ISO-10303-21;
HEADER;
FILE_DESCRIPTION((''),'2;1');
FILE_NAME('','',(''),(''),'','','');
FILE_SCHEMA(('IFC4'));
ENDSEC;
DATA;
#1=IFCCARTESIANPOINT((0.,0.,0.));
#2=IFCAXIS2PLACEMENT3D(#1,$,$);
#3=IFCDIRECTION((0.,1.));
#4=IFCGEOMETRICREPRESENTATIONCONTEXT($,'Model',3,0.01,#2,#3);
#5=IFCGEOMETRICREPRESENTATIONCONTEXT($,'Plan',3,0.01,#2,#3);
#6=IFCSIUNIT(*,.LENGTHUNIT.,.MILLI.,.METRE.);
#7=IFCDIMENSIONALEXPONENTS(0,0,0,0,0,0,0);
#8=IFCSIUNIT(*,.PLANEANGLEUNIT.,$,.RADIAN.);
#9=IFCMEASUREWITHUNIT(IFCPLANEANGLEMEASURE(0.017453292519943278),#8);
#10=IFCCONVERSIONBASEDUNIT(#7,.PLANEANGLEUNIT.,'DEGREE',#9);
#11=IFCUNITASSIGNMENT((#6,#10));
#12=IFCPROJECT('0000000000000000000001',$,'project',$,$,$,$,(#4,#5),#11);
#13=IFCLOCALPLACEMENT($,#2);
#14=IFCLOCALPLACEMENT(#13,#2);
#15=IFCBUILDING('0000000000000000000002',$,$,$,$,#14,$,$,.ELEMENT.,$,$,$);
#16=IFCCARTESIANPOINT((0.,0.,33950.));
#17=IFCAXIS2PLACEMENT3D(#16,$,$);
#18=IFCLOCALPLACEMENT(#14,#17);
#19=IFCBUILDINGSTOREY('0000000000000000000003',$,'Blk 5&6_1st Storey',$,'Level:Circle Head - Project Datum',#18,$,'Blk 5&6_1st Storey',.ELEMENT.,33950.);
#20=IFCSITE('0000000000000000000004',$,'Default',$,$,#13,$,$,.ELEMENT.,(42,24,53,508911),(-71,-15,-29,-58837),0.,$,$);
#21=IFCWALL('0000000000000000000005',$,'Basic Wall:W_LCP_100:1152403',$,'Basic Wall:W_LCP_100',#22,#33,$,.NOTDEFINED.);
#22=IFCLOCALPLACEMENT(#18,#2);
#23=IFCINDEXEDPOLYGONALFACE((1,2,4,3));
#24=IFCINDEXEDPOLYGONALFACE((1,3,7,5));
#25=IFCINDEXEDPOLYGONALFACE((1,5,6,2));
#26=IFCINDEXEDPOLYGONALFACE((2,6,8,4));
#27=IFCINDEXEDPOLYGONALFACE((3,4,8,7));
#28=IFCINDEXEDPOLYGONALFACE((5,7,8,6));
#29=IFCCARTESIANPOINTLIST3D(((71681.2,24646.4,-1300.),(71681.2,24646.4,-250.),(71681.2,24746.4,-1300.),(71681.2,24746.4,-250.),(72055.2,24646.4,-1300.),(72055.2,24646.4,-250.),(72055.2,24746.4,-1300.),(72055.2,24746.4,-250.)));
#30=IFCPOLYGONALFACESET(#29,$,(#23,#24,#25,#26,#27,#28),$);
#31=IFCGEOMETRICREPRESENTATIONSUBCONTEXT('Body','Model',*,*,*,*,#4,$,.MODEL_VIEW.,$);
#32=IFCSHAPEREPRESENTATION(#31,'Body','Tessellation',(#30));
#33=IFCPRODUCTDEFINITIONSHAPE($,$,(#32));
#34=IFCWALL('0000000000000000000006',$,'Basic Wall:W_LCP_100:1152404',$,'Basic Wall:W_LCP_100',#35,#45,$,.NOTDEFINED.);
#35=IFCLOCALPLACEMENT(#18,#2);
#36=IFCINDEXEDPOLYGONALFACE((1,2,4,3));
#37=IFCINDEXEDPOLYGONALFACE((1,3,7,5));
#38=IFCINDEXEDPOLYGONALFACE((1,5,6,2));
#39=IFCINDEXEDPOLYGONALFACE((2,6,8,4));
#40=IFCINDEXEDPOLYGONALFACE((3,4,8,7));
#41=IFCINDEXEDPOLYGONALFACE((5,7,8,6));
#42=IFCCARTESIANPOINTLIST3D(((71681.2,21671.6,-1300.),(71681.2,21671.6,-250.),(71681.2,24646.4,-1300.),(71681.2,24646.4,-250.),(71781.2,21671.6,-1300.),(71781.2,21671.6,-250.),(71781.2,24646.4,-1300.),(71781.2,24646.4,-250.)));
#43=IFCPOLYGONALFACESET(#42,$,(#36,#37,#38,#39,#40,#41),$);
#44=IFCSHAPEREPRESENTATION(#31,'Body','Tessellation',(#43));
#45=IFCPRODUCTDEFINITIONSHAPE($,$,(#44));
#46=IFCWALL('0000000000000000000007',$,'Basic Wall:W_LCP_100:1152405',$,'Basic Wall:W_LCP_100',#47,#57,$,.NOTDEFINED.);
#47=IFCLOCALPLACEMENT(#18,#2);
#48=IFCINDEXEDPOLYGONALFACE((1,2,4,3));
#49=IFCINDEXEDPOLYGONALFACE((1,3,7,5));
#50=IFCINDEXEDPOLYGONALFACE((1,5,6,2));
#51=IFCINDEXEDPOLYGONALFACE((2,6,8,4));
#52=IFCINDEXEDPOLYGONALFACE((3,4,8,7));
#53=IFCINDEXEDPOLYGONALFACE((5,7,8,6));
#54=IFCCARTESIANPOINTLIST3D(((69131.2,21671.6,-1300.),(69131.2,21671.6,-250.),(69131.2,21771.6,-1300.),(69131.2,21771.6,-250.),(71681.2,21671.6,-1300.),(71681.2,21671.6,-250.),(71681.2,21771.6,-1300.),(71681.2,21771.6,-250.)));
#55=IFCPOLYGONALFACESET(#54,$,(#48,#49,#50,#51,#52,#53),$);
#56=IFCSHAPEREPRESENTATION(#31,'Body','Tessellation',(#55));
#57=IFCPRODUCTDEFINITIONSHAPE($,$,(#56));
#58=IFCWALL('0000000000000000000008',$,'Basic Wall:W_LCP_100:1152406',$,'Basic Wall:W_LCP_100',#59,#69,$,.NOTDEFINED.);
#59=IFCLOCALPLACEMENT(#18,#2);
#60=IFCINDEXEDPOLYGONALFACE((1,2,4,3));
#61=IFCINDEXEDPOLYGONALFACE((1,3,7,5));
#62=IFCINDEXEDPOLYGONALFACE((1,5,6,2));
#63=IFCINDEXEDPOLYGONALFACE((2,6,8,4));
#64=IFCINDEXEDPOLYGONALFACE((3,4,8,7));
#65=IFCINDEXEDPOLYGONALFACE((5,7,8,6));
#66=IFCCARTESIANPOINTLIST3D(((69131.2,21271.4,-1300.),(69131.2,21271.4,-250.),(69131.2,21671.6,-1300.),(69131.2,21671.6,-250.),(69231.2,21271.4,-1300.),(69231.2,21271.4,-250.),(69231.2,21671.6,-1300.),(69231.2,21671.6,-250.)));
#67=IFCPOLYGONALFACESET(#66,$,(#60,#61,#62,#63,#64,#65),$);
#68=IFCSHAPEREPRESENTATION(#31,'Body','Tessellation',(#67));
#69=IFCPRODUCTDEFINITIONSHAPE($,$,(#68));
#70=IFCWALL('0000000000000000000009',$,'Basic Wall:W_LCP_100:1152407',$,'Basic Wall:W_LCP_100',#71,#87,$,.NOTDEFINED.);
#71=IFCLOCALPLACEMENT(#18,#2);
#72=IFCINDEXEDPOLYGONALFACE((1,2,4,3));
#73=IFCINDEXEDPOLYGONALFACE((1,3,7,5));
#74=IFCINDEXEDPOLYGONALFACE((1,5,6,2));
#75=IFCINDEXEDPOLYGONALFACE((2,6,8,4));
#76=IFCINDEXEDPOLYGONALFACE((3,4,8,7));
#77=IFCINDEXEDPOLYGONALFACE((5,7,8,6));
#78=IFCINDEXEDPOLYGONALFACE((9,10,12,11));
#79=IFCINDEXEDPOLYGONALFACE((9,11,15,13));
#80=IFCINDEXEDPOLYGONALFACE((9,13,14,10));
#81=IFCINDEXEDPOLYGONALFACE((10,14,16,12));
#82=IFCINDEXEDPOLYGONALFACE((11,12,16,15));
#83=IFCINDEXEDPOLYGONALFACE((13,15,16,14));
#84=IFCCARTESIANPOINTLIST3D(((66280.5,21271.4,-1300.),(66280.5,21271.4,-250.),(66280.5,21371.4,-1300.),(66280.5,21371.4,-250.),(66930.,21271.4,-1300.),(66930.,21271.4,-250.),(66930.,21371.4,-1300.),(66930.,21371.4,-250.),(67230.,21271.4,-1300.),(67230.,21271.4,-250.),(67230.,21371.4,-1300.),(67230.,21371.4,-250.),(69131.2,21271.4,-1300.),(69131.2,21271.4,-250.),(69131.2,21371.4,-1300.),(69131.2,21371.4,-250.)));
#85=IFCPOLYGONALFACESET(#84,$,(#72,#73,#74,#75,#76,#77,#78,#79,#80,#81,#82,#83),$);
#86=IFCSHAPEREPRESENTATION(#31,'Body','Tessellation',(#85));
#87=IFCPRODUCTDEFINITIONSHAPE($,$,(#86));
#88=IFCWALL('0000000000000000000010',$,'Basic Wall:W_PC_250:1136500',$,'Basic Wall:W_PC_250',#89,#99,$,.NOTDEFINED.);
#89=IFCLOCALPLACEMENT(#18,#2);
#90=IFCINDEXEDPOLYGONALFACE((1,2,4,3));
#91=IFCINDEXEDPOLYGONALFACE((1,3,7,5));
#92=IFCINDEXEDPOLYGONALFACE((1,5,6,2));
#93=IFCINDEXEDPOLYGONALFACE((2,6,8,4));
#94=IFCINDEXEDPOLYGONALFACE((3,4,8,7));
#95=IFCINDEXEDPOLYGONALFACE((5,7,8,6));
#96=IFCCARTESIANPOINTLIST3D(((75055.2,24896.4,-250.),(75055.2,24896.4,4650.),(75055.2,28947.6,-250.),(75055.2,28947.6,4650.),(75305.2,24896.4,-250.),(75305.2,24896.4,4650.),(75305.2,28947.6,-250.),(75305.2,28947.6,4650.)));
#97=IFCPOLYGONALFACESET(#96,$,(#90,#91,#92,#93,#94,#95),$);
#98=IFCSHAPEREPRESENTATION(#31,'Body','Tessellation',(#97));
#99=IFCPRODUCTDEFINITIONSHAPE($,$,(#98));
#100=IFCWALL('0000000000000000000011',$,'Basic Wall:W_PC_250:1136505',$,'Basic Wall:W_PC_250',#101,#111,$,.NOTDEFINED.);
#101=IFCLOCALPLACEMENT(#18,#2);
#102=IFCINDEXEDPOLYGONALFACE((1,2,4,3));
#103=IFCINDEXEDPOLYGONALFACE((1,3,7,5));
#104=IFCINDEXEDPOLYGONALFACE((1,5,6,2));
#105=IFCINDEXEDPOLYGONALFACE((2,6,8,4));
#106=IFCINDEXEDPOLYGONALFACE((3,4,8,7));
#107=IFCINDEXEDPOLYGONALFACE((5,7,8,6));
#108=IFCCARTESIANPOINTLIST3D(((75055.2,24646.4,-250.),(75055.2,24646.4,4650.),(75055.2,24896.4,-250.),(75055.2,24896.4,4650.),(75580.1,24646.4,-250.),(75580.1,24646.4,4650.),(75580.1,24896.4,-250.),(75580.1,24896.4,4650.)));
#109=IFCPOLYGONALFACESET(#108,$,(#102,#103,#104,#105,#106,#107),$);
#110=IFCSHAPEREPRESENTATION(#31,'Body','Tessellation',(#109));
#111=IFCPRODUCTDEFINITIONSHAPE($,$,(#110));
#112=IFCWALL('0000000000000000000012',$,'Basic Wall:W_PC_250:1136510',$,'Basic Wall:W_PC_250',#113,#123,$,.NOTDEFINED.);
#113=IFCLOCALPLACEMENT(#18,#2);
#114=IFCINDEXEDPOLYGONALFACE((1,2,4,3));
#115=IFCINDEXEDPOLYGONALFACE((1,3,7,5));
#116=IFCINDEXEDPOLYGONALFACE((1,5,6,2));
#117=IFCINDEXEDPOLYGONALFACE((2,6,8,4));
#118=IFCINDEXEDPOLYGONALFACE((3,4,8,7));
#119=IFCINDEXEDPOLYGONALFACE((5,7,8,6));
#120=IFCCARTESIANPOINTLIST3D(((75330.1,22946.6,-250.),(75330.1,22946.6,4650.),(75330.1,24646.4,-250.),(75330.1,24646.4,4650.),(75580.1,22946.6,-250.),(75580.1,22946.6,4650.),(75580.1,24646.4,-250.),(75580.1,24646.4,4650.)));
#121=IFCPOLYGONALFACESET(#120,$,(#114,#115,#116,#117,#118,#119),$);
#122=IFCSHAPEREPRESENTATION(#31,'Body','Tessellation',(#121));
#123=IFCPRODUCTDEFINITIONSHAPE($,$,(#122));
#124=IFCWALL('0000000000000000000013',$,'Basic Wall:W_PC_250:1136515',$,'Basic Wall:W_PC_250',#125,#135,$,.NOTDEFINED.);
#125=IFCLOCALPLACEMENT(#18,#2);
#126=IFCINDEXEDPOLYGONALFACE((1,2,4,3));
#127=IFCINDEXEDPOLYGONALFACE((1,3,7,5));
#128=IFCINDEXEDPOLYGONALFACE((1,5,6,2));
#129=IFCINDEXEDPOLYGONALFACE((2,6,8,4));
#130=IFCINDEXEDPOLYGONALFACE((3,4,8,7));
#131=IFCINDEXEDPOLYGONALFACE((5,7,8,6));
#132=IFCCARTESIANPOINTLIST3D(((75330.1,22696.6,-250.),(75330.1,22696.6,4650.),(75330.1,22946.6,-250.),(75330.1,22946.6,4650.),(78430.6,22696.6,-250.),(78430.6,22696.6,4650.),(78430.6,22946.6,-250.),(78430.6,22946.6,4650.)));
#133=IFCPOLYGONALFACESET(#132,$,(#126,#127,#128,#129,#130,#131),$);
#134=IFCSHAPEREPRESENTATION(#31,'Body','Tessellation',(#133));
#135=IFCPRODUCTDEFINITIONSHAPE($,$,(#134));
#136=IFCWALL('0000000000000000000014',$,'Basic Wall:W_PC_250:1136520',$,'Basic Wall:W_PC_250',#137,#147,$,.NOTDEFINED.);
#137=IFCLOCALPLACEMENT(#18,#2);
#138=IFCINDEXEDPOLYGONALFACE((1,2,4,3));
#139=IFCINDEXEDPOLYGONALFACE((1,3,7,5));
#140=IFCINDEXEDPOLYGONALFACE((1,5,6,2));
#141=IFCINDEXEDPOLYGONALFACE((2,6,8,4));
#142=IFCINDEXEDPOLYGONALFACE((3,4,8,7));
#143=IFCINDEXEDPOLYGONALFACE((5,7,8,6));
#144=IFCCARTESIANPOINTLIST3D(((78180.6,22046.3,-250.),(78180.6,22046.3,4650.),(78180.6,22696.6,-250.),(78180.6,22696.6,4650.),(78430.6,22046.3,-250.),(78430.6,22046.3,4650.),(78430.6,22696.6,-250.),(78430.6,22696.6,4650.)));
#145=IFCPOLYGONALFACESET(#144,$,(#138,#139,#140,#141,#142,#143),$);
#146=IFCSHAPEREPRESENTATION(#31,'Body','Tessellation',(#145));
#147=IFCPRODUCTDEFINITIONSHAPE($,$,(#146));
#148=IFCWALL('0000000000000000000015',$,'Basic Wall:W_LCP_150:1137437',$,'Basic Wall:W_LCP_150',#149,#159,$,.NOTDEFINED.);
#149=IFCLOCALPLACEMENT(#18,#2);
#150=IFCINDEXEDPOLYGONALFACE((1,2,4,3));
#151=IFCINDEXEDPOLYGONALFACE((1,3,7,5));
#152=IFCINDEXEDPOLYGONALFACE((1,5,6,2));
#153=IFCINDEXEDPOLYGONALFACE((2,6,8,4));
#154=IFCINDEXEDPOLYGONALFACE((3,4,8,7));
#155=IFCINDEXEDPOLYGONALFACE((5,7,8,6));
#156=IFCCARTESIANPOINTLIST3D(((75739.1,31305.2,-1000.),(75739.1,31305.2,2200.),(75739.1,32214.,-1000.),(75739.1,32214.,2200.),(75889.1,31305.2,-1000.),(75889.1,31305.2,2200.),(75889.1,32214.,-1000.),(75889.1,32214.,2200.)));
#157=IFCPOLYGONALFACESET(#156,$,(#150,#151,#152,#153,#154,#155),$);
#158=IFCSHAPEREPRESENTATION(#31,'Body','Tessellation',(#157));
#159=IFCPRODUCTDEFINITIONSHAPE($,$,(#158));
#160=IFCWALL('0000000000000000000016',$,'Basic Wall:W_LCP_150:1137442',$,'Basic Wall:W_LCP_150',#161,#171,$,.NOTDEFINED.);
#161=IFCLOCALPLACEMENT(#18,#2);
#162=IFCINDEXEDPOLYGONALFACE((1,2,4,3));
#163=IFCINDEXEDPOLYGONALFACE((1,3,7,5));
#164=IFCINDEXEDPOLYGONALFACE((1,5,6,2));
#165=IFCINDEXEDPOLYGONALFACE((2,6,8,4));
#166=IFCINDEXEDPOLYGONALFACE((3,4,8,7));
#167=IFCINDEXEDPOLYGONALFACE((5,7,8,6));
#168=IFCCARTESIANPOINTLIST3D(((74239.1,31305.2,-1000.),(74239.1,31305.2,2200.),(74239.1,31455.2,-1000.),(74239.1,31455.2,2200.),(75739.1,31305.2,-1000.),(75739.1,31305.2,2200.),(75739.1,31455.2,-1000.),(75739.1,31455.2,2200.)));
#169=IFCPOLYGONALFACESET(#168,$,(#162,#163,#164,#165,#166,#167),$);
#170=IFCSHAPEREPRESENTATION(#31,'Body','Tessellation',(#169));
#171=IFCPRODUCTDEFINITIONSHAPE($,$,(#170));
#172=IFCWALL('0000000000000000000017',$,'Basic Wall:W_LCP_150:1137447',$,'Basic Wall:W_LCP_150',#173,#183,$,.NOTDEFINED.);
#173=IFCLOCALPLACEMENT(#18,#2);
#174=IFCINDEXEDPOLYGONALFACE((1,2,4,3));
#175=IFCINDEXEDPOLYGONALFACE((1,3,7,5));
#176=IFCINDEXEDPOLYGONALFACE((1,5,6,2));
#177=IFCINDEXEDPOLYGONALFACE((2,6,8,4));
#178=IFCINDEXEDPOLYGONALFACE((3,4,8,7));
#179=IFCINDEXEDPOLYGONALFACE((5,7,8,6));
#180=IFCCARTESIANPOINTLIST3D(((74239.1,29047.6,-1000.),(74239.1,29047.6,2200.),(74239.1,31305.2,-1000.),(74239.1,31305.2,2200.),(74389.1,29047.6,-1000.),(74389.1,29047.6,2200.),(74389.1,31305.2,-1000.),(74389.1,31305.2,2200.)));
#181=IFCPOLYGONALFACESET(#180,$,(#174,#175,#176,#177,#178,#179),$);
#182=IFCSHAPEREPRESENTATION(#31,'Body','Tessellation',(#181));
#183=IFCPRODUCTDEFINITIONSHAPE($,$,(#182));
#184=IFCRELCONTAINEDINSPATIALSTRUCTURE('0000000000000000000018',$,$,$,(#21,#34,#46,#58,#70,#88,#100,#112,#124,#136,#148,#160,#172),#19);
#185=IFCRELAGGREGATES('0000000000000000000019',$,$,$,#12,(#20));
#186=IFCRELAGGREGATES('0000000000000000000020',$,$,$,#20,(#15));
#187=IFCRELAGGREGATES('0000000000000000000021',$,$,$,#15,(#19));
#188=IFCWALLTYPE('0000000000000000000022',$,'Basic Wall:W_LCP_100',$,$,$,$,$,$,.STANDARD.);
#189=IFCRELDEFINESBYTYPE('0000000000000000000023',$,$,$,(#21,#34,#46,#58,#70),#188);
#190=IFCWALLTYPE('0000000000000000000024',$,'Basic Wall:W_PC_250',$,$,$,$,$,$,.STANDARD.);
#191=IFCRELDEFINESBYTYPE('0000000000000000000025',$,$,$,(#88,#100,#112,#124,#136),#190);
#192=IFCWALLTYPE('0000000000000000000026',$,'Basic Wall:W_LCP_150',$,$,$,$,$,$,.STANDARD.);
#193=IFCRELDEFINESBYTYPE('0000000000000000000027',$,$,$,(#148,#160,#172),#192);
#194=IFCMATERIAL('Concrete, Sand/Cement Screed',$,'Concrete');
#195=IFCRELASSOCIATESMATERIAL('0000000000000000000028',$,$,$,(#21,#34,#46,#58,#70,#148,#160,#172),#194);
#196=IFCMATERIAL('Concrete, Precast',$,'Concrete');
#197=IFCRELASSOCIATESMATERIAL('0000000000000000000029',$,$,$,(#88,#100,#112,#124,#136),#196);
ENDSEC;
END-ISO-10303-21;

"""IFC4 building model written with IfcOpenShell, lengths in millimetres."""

from ifc_helpers import new_model, entity, si_unit, converted_unit, direction, frame, origin, place, context, subcontext, project, spatial, indexed_curve, outline, extrude, material, type_object, element, save


model = new_model("IFC4")

# Units and contexts
model_context = context("Model", 3, precision=0.01, world=origin(), true_north=direction((0.0, 1.0)))
plan_context = context("Plan", 3, precision=0.01, world=origin(), true_north=direction((0.0, 1.0)))
body_context = subcontext(model_context, "Body", "Model", "MODEL_VIEW")
ifc_project = project(units=[si_unit("LENGTHUNIT", "METRE", prefix="MILLI"), converted_unit("PLANEANGLEUNIT", "DEGREE", entity("IfcPlaneAngleMeasure", 0.017453292519943278), si_unit("PLANEANGLEUNIT", "RADIAN"), dimensions=[0, 0, 0, 0, 0, 0, 0])], contexts=[model_context, plan_context])

# Site, building, storey
site_placement = place(None, origin())
site = spatial("IfcSite", under=ifc_project, at=site_placement, Name="Default", CompositionType="ELEMENT", RefLatitude=(42, 24, 53, 508911), RefLongitude=(-71, -15, -29, -58837), RefElevation=0.0)
building_placement = place(site_placement, origin())
building = spatial("IfcBuilding", under=site, at=building_placement, CompositionType="ELEMENT")
storey_placement = place(building_placement, frame((0.0, 0.0, 33950.0)))
storey = spatial("IfcBuildingStorey", under=building, at=storey_placement, Name="Blk 5&6_1st Storey", ObjectType="Level:Circle Head - Project Datum", LongName="Blk 5&6_1st Storey", CompositionType="ELEMENT", Elevation=33950.0)

# Walls
ifc_material_1 = material(Name="Concrete, Sand/Cement Screed", Category="Concrete")
wall_type_1 = type_object("IfcWallType", Name="Basic Wall:W_LCP_100", PredefinedType="STANDARD")
wall_1_placement = place(storey_placement, frame((72055.2, 24696.4, -1300.0), z_axis=(0.0, 0.0, 1.0), x_axis=(-1.0, 0.0, 0.0)))
element("IfcWall", 1, at=wall_1_placement, inside=storey, type_object=wall_type_1, material=ifc_material_1, Name="Basic Wall:W_LCP_100:1152403", ObjectType="Basic Wall:W_LCP_100", PredefinedType="NOTDEFINED", context=body_context, shape_type="SweptSolid", body=[
    extrude(outline(indexed_curve([(373.9, 50.0), (0.0, 50.0), (0.0, -50.0), (373.9, -50.0), (373.9, 50.0)], self_intersect=False)), origin(), (0.0, 0.0, 1.0), 1050.0),
])
wall_2_placement = place(storey_placement, frame((71731.2, 24646.4, -1300.0), z_axis=(0.0, 0.0, 1.0), x_axis=(0.0, -1.0, 0.0)))
element("IfcWall", 2, at=wall_2_placement, inside=storey, type_object=wall_type_1, material=ifc_material_1, Name="Basic Wall:W_LCP_100:1152404", ObjectType="Basic Wall:W_LCP_100", PredefinedType="NOTDEFINED", context=body_context, shape_type="SweptSolid", body=[
    extrude(outline(indexed_curve([(2974.8, 50.0), (0.0, 50.0), (0.0, -50.0), (2974.8, -50.0), (2974.8, 50.0)], self_intersect=False)), origin(), (0.0, 0.0, 1.0), 1050.0),
])
wall_3_placement = place(storey_placement, frame((71681.2, 21721.6, -1300.0), z_axis=(0.0, 0.0, 1.0), x_axis=(-1.0, 0.0, 0.0)))
element("IfcWall", 3, at=wall_3_placement, inside=storey, type_object=wall_type_1, material=ifc_material_1, Name="Basic Wall:W_LCP_100:1152405", ObjectType="Basic Wall:W_LCP_100", PredefinedType="NOTDEFINED", context=body_context, shape_type="SweptSolid", body=[
    extrude(outline(indexed_curve([(2550.0, 50.0), (0.0, 50.0), (0.0, -50.0), (2550.0, -50.0), (2550.0, 50.0)], self_intersect=False)), origin(), (0.0, 0.0, 1.0), 1050.0),
])
wall_4_placement = place(storey_placement, frame((69181.2, 21671.6, -1300.0), z_axis=(0.0, 0.0, 1.0), x_axis=(0.0, -1.0, 0.0)))
element("IfcWall", 4, at=wall_4_placement, inside=storey, type_object=wall_type_1, material=ifc_material_1, Name="Basic Wall:W_LCP_100:1152406", ObjectType="Basic Wall:W_LCP_100", PredefinedType="NOTDEFINED", context=body_context, shape_type="SweptSolid", body=[
    extrude(outline(indexed_curve([(400.2, 50.0), (0.0, 50.0), (0.0, -50.0), (400.2, -50.0), (400.2, 50.0)], self_intersect=False)), origin(), (0.0, 0.0, 1.0), 1050.0),
])

# Wall, opening
wall_5_placement = place(storey_placement, frame((69131.2, 21321.4, -1300.0), z_axis=(0.0, 0.0, 1.0), x_axis=(-1.0, 0.0, 0.0)))
wall_5 = element("IfcWall", 5, at=wall_5_placement, inside=storey, type_object=wall_type_1, material=ifc_material_1, Name="Basic Wall:W_LCP_100:1152407", ObjectType="Basic Wall:W_LCP_100", PredefinedType="NOTDEFINED", context=body_context, shape_type="SweptSolid", body=[
    extrude(outline(indexed_curve([(2850.7, 50.0), (0.0, 50.0), (0.0, -50.0), (2850.7, -50.0), (2850.7, 50.0)], self_intersect=False)), origin(), (0.0, 0.0, 1.0), 1050.0),
])
opening_placement = place(storey_placement, frame((69131.2, 21321.4, -1300.0), z_axis=(0.0, 0.0, 1.0), x_axis=(-1.0, 0.0, 0.0)))
element("IfcOpeningElement", 6, at=opening_placement, cuts=wall_5, PredefinedType="OPENING", context=body_context, shape_type="SweptSolid", body=[
    extrude(outline(indexed_curve([(-525.0, -50.0), (525.0, -50.0), (525.0, 50.0), (-525.0, 50.0), (-525.0, -50.0)], self_intersect=False)), frame((2201.2, 0.0, 525.0), z_axis=(-1.0, 0.0, 0.0), x_axis=(0.0, 0.0, 1.0)), (0.0, 0.0, 1.0), 300.0),
])

# Walls
ifc_material_2 = material(Name="Concrete, Precast", Category="Concrete")
wall_type_2 = type_object("IfcWallType", Name="Basic Wall:W_PC_250", PredefinedType="STANDARD")
wall_6_placement = place(storey_placement, frame((75180.2, 28947.6, -250.0), z_axis=(0.0, 0.0, 1.0), x_axis=(0.0, -1.0, 0.0)))
element("IfcWall", 7, at=wall_6_placement, inside=storey, type_object=wall_type_2, material=ifc_material_2, Name="Basic Wall:W_PC_250:1136500", ObjectType="Basic Wall:W_PC_250", PredefinedType="NOTDEFINED", context=body_context, shape_type="SweptSolid", body=[
    extrude(outline(indexed_curve([(4051.2, 125.0), (0.0, 125.0), (0.0, -125.0), (4051.2, -125.0), (4051.2, 125.0)], self_intersect=False)), origin(), (0.0, 0.0, 1.0), 4900.0),
])
wall_7_placement = place(storey_placement, frame((75055.2, 24771.4, -250.0)))
element("IfcWall", 8, at=wall_7_placement, inside=storey, type_object=wall_type_2, material=ifc_material_2, Name="Basic Wall:W_PC_250:1136505", ObjectType="Basic Wall:W_PC_250", PredefinedType="NOTDEFINED", context=body_context, shape_type="SweptSolid", body=[
    extrude(outline(indexed_curve([(524.9, 125.0), (0.0, 125.0), (0.0, -125.0), (524.9, -125.0), (524.9, 125.0)], self_intersect=False)), origin(), (0.0, 0.0, 1.0), 4900.0),
])
wall_8_placement = place(storey_placement, frame((75455.1, 24646.4, -250.0), z_axis=(0.0, 0.0, 1.0), x_axis=(0.0, -1.0, 0.0)))
element("IfcWall", 9, at=wall_8_placement, inside=storey, type_object=wall_type_2, material=ifc_material_2, Name="Basic Wall:W_PC_250:1136510", ObjectType="Basic Wall:W_PC_250", PredefinedType="NOTDEFINED", context=body_context, shape_type="SweptSolid", body=[
    extrude(outline(indexed_curve([(1699.8, 125.0), (0.0, 125.0), (0.0, -125.0), (1699.8, -125.0), (1699.8, 125.0)], self_intersect=False)), origin(), (0.0, 0.0, 1.0), 4900.0),
])
wall_9_placement = place(storey_placement, frame((75330.1, 22821.6, -250.0)))
element("IfcWall", 10, at=wall_9_placement, inside=storey, type_object=wall_type_2, material=ifc_material_2, Name="Basic Wall:W_PC_250:1136515", ObjectType="Basic Wall:W_PC_250", PredefinedType="NOTDEFINED", context=body_context, shape_type="SweptSolid", body=[
    extrude(outline(indexed_curve([(3100.5, 125.0), (0.0, 125.0), (0.0, -125.0), (3100.5, -125.0), (3100.5, 125.0)], self_intersect=False)), origin(), (0.0, 0.0, 1.0), 4900.0),
])
wall_10_placement = place(storey_placement, frame((78305.6, 22696.6, -250.0), z_axis=(0.0, 0.0, 1.0), x_axis=(0.0, -1.0, 0.0)))
element("IfcWall", 11, at=wall_10_placement, inside=storey, type_object=wall_type_2, material=ifc_material_2, Name="Basic Wall:W_PC_250:1136520", ObjectType="Basic Wall:W_PC_250", PredefinedType="NOTDEFINED", context=body_context, shape_type="SweptSolid", body=[
    extrude(outline(indexed_curve([(650.3, 125.0), (0.0, 125.0), (0.0, -125.0), (650.3, -125.0), (650.3, 125.0)], self_intersect=False)), origin(), (0.0, 0.0, 1.0), 4900.0),
])
wall_type_3 = type_object("IfcWallType", Name="Basic Wall:W_LCP_150", PredefinedType="STANDARD")
wall_11_placement = place(storey_placement, frame((75814.1, 32214.0, -1000.0), z_axis=(0.0, 0.0, 1.0), x_axis=(0.0, -1.0, 0.0)))
element("IfcWall", 12, at=wall_11_placement, inside=storey, type_object=wall_type_3, material=ifc_material_1, Name="Basic Wall:W_LCP_150:1137437", ObjectType="Basic Wall:W_LCP_150", PredefinedType="NOTDEFINED", context=body_context, shape_type="SweptSolid", body=[
    extrude(outline(indexed_curve([(908.8, 75.0), (0.0, 75.0), (0.0, -75.0), (908.8, -75.0), (908.8, 75.0)], self_intersect=False)), origin(), (0.0, 0.0, 1.0), 3200.0),
])
wall_12_placement = place(storey_placement, frame((75739.1, 31380.2, -1000.0), z_axis=(0.0, 0.0, 1.0), x_axis=(-1.0, 0.0, 0.0)))
element("IfcWall", 13, at=wall_12_placement, inside=storey, type_object=wall_type_3, material=ifc_material_1, Name="Basic Wall:W_LCP_150:1137442", ObjectType="Basic Wall:W_LCP_150", PredefinedType="NOTDEFINED", context=body_context, shape_type="SweptSolid", body=[
    extrude(outline(indexed_curve([(1500.0, 75.0), (0.0, 75.0), (0.0, -75.0), (1500.0, -75.0), (1500.0, 75.0)], self_intersect=False)), origin(), (0.0, 0.0, 1.0), 3200.0),
])
wall_13_placement = place(storey_placement, frame((74314.1, 31305.2, -1000.0), z_axis=(0.0, 0.0, 1.0), x_axis=(0.0, -1.0, 0.0)))
element("IfcWall", 14, at=wall_13_placement, inside=storey, type_object=wall_type_3, material=ifc_material_1, Name="Basic Wall:W_LCP_150:1137447", ObjectType="Basic Wall:W_LCP_150", PredefinedType="NOTDEFINED", context=body_context, shape_type="SweptSolid", body=[
    extrude(outline(indexed_curve([(2257.6, 75.0), (0.0, 75.0), (0.0, -75.0), (2257.6, -75.0), (2257.6, 75.0)], self_intersect=False)), origin(), (0.0, 0.0, 1.0), 3200.0),
])

save(model, "model.ifc")
